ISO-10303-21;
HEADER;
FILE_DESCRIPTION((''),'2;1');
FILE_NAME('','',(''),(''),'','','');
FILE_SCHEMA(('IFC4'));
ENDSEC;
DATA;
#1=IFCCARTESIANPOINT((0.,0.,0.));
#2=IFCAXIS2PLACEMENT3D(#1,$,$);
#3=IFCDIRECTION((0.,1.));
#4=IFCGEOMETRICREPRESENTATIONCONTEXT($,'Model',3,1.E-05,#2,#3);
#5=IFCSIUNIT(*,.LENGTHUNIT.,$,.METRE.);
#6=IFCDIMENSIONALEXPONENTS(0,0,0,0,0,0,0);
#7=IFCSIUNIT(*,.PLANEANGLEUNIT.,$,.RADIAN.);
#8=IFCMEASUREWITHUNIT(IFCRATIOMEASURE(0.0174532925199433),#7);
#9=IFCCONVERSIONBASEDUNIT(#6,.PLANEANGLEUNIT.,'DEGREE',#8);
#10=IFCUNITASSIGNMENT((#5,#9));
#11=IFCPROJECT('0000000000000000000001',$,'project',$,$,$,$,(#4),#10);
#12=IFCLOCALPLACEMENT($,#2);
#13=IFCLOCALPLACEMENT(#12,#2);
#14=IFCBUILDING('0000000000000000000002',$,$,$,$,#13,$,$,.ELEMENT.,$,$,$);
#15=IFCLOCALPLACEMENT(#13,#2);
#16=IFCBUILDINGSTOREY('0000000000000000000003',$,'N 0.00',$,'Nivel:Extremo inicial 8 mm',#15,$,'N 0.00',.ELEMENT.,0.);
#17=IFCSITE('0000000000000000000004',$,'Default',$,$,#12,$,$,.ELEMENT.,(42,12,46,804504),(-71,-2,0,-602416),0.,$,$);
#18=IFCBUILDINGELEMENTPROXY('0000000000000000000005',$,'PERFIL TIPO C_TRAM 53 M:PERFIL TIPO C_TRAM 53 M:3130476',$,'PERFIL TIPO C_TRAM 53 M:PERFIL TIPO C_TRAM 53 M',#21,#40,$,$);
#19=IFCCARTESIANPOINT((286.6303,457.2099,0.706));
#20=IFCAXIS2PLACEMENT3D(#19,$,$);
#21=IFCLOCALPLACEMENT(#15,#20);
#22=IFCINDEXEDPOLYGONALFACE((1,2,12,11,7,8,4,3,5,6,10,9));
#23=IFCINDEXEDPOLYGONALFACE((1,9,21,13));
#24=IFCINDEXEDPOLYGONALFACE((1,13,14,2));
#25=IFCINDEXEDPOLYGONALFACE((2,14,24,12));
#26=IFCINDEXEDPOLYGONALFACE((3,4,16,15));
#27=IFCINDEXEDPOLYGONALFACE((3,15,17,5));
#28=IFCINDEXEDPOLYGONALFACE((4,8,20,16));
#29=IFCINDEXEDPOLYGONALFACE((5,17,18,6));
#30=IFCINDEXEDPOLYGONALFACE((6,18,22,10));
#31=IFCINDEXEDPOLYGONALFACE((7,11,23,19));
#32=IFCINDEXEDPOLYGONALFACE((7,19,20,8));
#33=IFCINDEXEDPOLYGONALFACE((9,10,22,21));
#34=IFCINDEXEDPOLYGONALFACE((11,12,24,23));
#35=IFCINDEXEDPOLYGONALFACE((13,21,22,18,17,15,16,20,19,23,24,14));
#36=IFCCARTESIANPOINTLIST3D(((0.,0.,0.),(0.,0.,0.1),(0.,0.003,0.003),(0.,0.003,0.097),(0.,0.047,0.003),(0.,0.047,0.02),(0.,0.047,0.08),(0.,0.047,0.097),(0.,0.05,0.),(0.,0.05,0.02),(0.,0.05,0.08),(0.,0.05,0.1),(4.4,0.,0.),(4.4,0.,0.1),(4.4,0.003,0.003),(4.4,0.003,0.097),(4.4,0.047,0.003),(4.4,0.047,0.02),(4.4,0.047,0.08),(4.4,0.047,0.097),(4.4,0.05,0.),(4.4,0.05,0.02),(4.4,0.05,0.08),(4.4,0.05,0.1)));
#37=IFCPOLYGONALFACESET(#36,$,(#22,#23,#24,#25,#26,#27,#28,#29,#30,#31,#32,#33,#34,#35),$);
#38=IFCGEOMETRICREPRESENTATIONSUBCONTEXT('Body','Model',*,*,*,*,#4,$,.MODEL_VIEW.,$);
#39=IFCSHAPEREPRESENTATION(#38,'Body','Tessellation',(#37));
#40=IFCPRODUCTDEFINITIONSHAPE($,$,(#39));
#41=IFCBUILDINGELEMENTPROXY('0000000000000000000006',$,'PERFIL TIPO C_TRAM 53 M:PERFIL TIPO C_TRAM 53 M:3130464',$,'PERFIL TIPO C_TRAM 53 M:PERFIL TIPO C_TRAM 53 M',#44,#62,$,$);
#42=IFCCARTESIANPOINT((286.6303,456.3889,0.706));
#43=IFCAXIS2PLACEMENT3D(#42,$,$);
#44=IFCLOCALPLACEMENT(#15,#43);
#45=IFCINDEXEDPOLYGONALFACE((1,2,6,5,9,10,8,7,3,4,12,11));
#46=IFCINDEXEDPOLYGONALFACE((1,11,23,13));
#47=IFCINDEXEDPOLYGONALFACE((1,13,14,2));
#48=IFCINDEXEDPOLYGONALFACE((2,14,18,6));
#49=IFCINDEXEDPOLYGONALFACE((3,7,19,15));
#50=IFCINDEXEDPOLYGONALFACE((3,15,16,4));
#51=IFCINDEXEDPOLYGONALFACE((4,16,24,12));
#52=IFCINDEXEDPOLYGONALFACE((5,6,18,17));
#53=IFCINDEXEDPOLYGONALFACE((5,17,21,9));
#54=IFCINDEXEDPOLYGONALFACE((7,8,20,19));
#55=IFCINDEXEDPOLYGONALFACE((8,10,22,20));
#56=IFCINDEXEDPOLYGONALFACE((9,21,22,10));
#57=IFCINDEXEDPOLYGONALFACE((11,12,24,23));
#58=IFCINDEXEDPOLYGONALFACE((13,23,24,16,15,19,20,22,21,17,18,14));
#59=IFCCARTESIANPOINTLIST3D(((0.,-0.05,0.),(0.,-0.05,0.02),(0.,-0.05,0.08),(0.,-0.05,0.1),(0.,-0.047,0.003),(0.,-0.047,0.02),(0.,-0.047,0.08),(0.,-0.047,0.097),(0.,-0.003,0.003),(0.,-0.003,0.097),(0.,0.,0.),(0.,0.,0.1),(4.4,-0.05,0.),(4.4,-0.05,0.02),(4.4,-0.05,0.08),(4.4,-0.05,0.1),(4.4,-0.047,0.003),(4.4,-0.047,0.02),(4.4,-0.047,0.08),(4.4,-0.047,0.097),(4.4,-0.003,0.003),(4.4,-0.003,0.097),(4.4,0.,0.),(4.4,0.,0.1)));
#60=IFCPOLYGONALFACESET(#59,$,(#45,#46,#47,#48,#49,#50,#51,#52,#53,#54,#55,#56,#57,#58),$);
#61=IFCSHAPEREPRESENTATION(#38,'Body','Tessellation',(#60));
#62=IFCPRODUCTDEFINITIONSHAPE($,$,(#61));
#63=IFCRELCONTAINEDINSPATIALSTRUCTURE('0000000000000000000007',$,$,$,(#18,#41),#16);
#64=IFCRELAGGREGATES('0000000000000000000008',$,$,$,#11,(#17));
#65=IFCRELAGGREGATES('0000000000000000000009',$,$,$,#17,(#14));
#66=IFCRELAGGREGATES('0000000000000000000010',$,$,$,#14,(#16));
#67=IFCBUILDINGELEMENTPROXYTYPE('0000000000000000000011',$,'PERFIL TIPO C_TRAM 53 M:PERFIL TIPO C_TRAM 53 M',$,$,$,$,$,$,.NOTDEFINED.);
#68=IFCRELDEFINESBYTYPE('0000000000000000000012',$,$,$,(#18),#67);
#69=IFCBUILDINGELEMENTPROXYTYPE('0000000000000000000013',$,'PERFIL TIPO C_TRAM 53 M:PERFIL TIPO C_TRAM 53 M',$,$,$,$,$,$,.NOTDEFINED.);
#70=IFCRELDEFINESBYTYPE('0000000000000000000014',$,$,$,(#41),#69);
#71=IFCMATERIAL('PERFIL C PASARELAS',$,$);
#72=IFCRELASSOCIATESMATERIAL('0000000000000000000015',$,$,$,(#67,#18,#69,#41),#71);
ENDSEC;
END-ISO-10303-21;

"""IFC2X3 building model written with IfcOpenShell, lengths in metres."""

from ifc_helpers import new_model, entity, si_unit, converted_unit, direction, frame, origin, place, context, subcontext, project, spatial, polyline, outline, extrude, source, transform, mapped, material, type_object, type_shapes, element, save


model = new_model("IFC2X3")

# Units and contexts
model_context = context("Model", 3, precision=1e-05, world=origin(), true_north=direction((0.0, 1.0)))
body_context = subcontext(model_context, "Body", "Model", "MODEL_VIEW")
ifc_project = project(units=[si_unit("LENGTHUNIT", "METRE"), converted_unit("PLANEANGLEUNIT", "DEGREE", entity("IfcRatioMeasure", 0.0174532925199433), si_unit("PLANEANGLEUNIT", "RADIAN"), dimensions=[0, 0, 0, 0, 0, 0, 0])], contexts=[model_context])

# Site, building, storey
site_placement = place(None, origin())
site = spatial("IfcSite", under=ifc_project, at=site_placement, Name="Default", CompositionType="ELEMENT", RefLatitude=(42, 12, 46, 804504), RefLongitude=(-71, -2, 0, -602416), RefElevation=0.0)
building_placement = place(site_placement, origin())
building = spatial("IfcBuilding", under=site, at=building_placement, CompositionType="ELEMENT")
storey_placement = place(building_placement, origin())
storey = spatial("IfcBuildingStorey", under=building, at=storey_placement, Name="N 0.00", ObjectType="Nivel:Extremo inicial 8 mm", LongName="N 0.00", CompositionType="ELEMENT", Elevation=0.0)

# Building element proxies
ifc_material_1 = material(Name="PERFIL C PASARELAS")
building_element_proxy_type_1 = type_object("IfcBuildingElementProxyType", Name="PERFIL TIPO C_TRAM 53 M:PERFIL TIPO C_TRAM 53 M", PredefinedType="NOTDEFINED", material=ifc_material_1)
shared_shape_1 = source(origin(), body_context, "Body", "SweptSolid", [
    extrude(outline(polyline([(-0.0172, 0.03), (-0.0142, 0.03), (-0.0142, 0.047), (0.0298, 0.047), (0.0298, -0.047), (-0.0142, -0.047), (-0.0142, -0.03), (-0.0172, -0.03), (-0.0172, -0.05), (0.0328, -0.05), (0.0328, 0.05), (-0.0172, 0.05), (-0.0172, 0.03)])), frame((0.0, 0.0328, 0.05), z_axis=(1.0, 0.0, 0.0), x_axis=(0.0, -1.0, 0.0)), (0.0, 0.0, 1.0), 4.4),
])
type_shapes(building_element_proxy_type_1, [shared_shape_1])
proxy_1_placement = place(storey_placement, frame((286.6303, 457.2099, 0.706)))
element("IfcBuildingElementProxy", 1, at=proxy_1_placement, inside=storey, type_object=building_element_proxy_type_1, material=ifc_material_1, Name="PERFIL TIPO C_TRAM 53 M:PERFIL TIPO C_TRAM 53 M:3130476", ObjectType="PERFIL TIPO C_TRAM 53 M:PERFIL TIPO C_TRAM 53 M", context=body_context, shape_type="MappedRepresentation", body=[
    mapped(shared_shape_1, transform((0.0, 0.0, 0.0), scale=1.0)),
])
building_element_proxy_type_2 = type_object("IfcBuildingElementProxyType", Name="PERFIL TIPO C_TRAM 53 M:PERFIL TIPO C_TRAM 53 M", PredefinedType="NOTDEFINED", material=ifc_material_1)
shared_shape_2 = source(origin(), body_context, "Body", "SweptSolid", [
    extrude(outline(polyline([(0.03, -0.0172), (0.05, -0.0172), (0.05, 0.0328), (-0.05, 0.0328), (-0.05, -0.0172), (-0.03, -0.0172), (-0.03, -0.0142), (-0.047, -0.0142), (-0.047, 0.0298), (0.047, 0.0298), (0.047, -0.0142), (0.03, -0.0142), (0.03, -0.0172)])), frame((0.0, -0.0328, 0.05), z_axis=(1.0, 0.0, 0.0), x_axis=(0.0, 0.0, -1.0)), (0.0, 0.0, 1.0), 4.4),
])
type_shapes(building_element_proxy_type_2, [shared_shape_2])
proxy_2_placement = place(storey_placement, frame((286.6303, 456.3889, 0.706)))
element("IfcBuildingElementProxy", 2, at=proxy_2_placement, inside=storey, type_object=building_element_proxy_type_2, material=ifc_material_1, Name="PERFIL TIPO C_TRAM 53 M:PERFIL TIPO C_TRAM 53 M:3130464", ObjectType="PERFIL TIPO C_TRAM 53 M:PERFIL TIPO C_TRAM 53 M", context=body_context, shape_type="MappedRepresentation", body=[
    mapped(shared_shape_2, transform((0.0, 0.0, 0.0), scale=1.0)),
])

save(model, "model.ifc")
